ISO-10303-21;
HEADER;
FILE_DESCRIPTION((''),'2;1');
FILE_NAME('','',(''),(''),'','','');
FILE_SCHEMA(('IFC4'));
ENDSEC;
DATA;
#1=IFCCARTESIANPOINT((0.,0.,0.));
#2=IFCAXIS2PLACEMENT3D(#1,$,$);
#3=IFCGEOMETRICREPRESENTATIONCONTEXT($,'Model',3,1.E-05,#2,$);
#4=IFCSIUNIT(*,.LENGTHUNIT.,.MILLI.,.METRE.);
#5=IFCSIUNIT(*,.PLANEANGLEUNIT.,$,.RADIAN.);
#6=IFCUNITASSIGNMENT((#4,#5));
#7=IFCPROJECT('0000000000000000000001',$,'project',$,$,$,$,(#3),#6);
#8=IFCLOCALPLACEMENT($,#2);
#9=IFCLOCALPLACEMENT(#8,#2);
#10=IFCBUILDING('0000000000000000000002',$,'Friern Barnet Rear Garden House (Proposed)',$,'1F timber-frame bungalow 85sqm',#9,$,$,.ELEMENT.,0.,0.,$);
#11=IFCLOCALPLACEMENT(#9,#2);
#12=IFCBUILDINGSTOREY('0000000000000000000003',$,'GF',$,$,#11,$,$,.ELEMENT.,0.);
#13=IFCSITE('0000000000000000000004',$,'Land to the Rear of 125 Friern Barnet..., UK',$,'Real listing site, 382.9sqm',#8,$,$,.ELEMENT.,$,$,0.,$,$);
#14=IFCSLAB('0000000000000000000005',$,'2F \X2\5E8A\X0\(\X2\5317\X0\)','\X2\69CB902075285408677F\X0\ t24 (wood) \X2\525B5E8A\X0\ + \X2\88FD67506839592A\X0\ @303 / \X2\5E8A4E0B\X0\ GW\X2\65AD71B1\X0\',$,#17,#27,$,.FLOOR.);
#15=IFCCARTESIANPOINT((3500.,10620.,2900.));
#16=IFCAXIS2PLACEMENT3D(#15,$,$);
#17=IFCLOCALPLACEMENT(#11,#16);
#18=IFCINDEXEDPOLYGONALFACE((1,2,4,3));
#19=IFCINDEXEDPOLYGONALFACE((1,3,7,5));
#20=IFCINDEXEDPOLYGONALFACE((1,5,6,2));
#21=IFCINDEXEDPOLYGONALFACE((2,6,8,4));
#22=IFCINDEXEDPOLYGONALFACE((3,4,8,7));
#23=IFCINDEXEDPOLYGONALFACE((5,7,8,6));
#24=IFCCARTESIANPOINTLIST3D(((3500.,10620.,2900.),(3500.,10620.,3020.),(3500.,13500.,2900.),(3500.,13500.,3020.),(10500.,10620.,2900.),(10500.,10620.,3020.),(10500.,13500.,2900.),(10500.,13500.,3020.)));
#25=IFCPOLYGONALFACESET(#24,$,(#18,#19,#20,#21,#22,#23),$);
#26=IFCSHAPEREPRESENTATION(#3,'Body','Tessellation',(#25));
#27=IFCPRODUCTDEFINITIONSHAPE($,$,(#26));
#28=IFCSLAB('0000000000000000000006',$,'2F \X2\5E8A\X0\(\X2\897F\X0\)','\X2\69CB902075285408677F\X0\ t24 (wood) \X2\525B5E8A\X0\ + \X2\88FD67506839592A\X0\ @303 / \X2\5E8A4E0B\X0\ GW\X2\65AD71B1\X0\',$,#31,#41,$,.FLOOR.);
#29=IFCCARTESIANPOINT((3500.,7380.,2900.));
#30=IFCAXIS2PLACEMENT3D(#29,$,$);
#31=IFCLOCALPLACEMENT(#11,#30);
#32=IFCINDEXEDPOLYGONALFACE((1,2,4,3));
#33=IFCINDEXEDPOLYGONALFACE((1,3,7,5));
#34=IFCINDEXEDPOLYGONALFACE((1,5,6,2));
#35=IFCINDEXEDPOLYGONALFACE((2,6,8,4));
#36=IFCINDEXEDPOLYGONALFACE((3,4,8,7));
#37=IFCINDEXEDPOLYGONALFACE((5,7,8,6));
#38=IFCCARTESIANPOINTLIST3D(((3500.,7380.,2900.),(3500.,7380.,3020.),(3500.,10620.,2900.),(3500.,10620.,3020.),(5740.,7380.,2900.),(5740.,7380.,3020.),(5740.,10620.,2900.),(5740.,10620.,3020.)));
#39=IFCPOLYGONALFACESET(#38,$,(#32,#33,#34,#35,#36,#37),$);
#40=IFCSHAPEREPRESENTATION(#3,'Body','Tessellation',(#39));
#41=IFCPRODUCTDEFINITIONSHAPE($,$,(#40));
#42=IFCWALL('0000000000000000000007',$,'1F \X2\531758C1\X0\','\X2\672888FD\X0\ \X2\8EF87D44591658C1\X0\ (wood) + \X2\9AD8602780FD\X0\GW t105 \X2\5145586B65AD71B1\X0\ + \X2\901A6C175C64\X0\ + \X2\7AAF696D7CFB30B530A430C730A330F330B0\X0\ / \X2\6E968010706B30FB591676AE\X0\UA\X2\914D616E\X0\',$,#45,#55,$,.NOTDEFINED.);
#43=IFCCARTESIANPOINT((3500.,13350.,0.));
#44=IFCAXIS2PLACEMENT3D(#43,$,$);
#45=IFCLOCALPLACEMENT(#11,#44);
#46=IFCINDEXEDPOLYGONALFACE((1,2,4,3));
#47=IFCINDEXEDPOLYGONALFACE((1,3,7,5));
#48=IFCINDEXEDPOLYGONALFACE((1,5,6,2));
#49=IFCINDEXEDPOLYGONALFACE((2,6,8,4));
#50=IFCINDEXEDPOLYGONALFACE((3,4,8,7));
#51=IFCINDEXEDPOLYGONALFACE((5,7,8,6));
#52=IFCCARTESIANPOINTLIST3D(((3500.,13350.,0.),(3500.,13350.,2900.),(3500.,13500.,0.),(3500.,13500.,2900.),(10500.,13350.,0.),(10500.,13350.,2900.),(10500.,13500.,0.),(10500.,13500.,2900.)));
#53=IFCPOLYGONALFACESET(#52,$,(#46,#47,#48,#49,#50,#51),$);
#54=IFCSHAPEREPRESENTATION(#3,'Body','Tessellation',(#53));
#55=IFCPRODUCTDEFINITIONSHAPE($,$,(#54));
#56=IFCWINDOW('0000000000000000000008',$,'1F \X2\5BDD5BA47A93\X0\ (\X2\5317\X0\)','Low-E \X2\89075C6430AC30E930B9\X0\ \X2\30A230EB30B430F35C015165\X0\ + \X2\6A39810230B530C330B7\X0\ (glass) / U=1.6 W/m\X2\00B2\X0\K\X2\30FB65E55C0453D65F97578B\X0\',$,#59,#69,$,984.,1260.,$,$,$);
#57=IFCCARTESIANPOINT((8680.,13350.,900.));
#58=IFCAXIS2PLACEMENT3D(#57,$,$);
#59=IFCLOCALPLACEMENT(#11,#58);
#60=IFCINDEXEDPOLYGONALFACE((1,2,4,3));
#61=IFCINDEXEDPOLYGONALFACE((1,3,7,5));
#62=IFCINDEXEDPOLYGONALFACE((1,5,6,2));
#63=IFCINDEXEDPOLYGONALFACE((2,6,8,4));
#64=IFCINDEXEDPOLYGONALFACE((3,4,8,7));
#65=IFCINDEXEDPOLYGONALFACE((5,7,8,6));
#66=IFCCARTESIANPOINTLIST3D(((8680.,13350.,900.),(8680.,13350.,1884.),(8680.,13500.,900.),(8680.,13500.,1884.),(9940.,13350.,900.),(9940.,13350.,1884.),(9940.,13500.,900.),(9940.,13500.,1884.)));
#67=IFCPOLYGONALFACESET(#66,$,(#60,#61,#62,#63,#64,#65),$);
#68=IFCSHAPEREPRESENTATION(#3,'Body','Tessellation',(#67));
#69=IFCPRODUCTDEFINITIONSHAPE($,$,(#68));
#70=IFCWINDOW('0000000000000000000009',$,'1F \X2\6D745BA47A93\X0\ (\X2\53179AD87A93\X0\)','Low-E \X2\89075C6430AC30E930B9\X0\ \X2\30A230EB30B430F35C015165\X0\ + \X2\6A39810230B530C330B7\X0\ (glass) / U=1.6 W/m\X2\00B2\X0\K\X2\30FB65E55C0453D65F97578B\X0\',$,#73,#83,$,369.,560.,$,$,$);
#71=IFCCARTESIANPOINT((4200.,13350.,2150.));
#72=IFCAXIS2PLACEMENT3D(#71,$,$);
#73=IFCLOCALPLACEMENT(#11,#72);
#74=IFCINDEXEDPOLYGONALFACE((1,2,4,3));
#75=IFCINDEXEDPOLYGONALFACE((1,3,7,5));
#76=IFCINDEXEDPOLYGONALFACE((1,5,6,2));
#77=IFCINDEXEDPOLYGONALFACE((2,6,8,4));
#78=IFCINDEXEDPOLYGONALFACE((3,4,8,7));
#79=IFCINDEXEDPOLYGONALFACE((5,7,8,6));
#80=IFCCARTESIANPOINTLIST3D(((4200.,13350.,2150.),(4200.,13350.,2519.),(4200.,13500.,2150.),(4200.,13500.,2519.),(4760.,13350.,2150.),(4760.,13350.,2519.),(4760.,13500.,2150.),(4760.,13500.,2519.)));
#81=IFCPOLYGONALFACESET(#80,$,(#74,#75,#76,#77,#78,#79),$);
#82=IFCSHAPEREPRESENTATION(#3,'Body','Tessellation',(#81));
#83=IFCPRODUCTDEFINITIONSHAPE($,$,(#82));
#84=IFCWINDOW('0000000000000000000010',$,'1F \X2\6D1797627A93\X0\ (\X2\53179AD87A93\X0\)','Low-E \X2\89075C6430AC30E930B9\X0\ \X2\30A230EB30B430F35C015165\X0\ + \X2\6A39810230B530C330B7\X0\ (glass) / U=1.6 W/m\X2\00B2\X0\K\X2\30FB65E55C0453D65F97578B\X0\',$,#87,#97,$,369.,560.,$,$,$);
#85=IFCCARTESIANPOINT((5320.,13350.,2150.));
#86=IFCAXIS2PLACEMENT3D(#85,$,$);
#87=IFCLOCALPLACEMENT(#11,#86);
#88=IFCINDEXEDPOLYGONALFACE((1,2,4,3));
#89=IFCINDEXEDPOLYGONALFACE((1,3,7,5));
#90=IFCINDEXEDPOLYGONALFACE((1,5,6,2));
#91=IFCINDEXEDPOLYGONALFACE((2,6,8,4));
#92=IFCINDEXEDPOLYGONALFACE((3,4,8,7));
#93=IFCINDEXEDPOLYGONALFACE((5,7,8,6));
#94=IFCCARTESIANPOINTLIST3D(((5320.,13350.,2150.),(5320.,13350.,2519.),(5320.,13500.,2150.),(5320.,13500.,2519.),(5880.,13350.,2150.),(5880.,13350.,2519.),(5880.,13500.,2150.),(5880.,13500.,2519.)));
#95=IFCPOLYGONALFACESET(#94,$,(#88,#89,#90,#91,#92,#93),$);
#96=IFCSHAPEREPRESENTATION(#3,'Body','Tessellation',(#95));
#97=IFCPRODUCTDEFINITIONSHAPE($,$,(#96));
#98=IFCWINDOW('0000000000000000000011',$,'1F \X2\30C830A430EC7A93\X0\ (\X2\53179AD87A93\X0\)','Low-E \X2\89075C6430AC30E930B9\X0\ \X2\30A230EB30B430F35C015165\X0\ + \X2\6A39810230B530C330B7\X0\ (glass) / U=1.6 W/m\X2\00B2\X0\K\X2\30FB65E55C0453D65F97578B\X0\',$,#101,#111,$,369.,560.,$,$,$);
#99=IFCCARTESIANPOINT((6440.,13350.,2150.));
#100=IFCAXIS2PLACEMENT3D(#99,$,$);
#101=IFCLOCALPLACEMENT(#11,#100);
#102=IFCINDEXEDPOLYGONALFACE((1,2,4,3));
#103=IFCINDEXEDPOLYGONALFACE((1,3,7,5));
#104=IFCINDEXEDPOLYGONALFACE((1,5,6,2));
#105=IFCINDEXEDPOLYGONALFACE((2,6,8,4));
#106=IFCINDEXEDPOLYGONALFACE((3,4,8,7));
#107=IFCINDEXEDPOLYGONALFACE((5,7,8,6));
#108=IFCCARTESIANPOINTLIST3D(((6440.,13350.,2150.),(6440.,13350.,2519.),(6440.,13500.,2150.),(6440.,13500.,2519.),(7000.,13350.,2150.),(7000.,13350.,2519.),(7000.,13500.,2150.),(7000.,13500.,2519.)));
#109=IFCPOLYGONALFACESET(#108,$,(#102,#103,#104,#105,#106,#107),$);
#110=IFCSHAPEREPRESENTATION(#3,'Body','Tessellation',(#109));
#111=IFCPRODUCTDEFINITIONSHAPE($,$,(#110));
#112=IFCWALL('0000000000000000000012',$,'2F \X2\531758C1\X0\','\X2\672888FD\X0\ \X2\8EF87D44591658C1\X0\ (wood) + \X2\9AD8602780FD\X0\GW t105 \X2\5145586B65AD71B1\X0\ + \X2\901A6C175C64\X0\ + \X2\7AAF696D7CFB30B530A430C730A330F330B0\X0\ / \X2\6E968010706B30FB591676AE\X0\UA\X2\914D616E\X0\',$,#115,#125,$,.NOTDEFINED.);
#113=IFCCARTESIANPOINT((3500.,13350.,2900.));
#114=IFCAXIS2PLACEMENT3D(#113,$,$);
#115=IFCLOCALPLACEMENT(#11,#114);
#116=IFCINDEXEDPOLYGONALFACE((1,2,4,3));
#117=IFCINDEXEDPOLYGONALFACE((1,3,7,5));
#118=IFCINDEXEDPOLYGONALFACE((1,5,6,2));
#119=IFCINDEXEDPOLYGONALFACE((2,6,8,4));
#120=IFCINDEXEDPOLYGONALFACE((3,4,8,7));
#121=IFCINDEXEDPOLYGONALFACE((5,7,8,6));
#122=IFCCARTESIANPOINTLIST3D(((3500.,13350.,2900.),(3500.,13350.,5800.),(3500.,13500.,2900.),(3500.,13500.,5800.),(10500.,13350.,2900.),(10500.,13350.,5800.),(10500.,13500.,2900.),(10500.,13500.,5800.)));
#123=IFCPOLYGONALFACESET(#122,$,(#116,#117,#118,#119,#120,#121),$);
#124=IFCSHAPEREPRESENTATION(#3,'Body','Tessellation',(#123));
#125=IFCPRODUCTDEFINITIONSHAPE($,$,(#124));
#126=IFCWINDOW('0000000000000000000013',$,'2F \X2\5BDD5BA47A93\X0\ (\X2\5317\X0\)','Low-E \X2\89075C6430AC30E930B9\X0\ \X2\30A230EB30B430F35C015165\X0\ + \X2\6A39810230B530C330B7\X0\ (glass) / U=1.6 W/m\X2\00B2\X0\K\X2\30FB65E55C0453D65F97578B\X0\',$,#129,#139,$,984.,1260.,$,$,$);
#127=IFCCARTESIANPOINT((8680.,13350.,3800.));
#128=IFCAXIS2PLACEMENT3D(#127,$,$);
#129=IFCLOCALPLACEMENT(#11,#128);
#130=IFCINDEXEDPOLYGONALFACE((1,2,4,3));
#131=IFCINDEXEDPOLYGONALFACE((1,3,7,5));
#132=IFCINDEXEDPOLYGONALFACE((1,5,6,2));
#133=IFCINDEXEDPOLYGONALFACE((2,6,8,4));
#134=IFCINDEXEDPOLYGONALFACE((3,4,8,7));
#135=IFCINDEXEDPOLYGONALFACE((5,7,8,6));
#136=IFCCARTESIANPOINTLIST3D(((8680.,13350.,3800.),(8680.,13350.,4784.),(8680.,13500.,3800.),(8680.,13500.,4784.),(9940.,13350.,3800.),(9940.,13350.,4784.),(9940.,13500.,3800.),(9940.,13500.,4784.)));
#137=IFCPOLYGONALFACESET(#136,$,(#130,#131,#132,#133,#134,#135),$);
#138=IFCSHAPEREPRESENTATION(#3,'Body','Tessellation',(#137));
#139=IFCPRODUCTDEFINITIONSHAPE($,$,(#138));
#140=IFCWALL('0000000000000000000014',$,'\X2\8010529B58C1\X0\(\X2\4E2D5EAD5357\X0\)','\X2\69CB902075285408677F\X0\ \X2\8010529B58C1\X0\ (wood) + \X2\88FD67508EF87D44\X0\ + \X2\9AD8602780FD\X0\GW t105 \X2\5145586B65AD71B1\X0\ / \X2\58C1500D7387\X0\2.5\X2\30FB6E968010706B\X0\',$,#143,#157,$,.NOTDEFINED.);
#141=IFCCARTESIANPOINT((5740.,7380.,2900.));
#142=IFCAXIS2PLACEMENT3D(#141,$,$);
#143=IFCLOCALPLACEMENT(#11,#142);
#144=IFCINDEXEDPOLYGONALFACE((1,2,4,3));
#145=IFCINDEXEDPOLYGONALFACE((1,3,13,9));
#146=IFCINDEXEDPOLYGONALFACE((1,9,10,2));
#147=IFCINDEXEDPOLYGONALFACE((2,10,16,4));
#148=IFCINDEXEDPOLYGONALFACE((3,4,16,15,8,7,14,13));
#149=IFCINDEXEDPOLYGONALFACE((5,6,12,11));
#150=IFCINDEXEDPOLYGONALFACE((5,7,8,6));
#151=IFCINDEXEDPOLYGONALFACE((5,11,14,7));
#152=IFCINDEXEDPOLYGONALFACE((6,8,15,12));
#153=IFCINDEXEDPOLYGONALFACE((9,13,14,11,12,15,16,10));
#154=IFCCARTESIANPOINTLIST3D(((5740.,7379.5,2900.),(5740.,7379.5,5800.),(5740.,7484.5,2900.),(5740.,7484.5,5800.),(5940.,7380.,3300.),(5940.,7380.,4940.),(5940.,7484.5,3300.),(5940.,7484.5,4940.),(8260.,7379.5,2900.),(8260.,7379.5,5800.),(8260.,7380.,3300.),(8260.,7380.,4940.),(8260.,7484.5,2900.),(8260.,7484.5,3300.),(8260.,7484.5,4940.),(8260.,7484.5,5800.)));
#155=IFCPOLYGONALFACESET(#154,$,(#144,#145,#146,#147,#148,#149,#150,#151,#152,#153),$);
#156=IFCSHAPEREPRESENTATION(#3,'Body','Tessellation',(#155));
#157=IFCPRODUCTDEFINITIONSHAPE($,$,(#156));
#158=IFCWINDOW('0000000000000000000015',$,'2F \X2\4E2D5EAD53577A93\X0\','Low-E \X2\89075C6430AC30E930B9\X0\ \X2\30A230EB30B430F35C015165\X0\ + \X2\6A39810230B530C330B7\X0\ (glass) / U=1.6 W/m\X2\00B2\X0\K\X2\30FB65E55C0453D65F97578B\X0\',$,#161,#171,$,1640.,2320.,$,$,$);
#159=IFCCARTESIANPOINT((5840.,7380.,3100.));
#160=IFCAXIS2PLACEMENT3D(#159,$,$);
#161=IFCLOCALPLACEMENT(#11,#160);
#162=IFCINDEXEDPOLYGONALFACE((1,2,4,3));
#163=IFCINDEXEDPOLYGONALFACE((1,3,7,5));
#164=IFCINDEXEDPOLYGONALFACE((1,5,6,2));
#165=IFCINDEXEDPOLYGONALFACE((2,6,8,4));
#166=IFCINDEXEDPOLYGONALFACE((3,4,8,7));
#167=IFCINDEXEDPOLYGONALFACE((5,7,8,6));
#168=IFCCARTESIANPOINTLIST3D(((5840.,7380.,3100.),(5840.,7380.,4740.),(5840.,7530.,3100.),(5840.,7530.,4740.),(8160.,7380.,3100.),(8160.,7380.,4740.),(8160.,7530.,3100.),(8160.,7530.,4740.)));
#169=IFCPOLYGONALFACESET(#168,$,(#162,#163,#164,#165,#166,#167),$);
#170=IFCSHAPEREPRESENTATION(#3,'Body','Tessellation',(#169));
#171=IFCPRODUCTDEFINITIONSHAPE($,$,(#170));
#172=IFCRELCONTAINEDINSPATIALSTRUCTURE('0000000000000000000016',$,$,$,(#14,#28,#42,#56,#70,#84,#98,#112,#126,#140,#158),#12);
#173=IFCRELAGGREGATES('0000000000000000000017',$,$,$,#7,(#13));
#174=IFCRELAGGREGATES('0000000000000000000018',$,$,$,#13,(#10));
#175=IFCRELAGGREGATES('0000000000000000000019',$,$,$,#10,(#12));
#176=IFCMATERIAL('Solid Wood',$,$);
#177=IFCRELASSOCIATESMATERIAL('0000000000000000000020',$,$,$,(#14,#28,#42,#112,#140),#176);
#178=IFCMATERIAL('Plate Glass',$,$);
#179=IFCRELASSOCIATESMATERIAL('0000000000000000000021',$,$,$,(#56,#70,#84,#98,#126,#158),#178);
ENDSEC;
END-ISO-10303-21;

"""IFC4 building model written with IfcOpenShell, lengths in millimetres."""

from ifc_helpers import new_model, si_unit, frame, frame_2d, origin, place, context, project, spatial, rectangle, extrude, material, element, fill, save


model = new_model("IFC4")

# Units and contexts
model_context = context("Model", 3, precision=1e-05, world=origin())
ifc_project = project(units=[si_unit("LENGTHUNIT", "METRE", prefix="MILLI"), si_unit("PLANEANGLEUNIT", "RADIAN")], contexts=[model_context])

# Site, building, storey
site_placement = place(None, origin())
site = spatial("IfcSite", under=ifc_project, at=site_placement, Name="Land to the Rear of 125 Friern Barnet..., UK", ObjectType="Real listing site, 382.9sqm", CompositionType="ELEMENT", RefElevation=0.0)
building_placement = place(site_placement, origin())
building = spatial("IfcBuilding", under=site, at=building_placement, Name="Friern Barnet Rear Garden House (Proposed)", ObjectType="1F timber-frame bungalow 85sqm", CompositionType="ELEMENT", ElevationOfRefHeight=0.0, ElevationOfTerrain=0.0)
storey_placement = place(building_placement, origin())
storey = spatial("IfcBuildingStorey", under=building, at=storey_placement, Name="GF", CompositionType="ELEMENT", Elevation=0.0)

# Slabs
ifc_material_1 = material(Name="Solid Wood")
slab_1_placement = place(storey_placement, frame((3500.0, 10620.0, 2900.0)))
element("IfcSlab", 1, at=slab_1_placement, inside=storey, material=ifc_material_1, Name="2F 床(北)", Description="構造用合板 t24 (wood) 剛床 + 製材根太 @303 / 床下 GW断熱", PredefinedType="FLOOR", context=model_context, shape_type="SweptSolid", body=[
    extrude(rectangle(XDim=7000.0, YDim=2880.0, at=frame_2d((3500.0, 1440.0))), frame((3500.0, 10620.0, 2900.0)), (0.0, 0.0, 1.0), 120.0),
])
slab_2_placement = place(storey_placement, frame((3500.0, 7380.0, 2900.0)))
element("IfcSlab", 2, at=slab_2_placement, inside=storey, material=ifc_material_1, Name="2F 床(西)", Description="構造用合板 t24 (wood) 剛床 + 製材根太 @303 / 床下 GW断熱", PredefinedType="FLOOR", context=model_context, shape_type="SweptSolid", body=[
    extrude(rectangle(XDim=2240.0, YDim=3240.0, at=frame_2d((1120.0, 1620.0))), frame((3500.0, 7380.0, 2900.0)), (0.0, 0.0, 1.0), 120.0),
])

# Wall, openings, windows
wall_1_placement = place(storey_placement, frame((3500.0, 13350.0, 0.0)))
wall_1 = element("IfcWall", 3, at=wall_1_placement, inside=storey, material=ifc_material_1, Name="1F 北壁", Description="木製 軸組外壁 (wood) + 高性能GW t105 充填断熱 + 通気層 + 窯業系サイディング / 準耐火・外皮UA配慮", PredefinedType="NOTDEFINED", context=model_context, shape_type="SweptSolid", body=[
    extrude(rectangle(XDim=7000.0, YDim=150.0, at=frame_2d((3500.0, 75.0))), frame((3500.0, 13350.0, 0.0)), (0.0, 0.0, 1.0), 2900.0),
])
opening_1_placement = place(storey_placement, frame((8680.0, 13350.0, 900.0)))
opening_1 = element("IfcOpeningElement", 4, at=opening_1_placement, cuts=wall_1, PredefinedType="NOTDEFINED", context=model_context, shape_type="SweptSolid", body=[
    extrude(rectangle(XDim=1260.0, YDim=150.0, at=frame_2d((630.0, 75.0))), frame((8680.0, 13350.0, 900.0)), (0.0, 0.0, 1.0), 984.0),
])
opening_2_placement = place(storey_placement, frame((4200.0, 13350.0, 2150.0)))
opening_2 = element("IfcOpeningElement", 5, at=opening_2_placement, cuts=wall_1, PredefinedType="NOTDEFINED", context=model_context, shape_type="SweptSolid", body=[
    extrude(rectangle(XDim=560.0, YDim=150.0, at=frame_2d((280.0, 75.0))), frame((4200.0, 13350.0, 2150.0)), (0.0, 0.0, 1.0), 369.0),
])
opening_3_placement = place(storey_placement, frame((5320.0, 13350.0, 2150.0)))
opening_3 = element("IfcOpeningElement", 6, at=opening_3_placement, cuts=wall_1, PredefinedType="NOTDEFINED", context=model_context, shape_type="SweptSolid", body=[
    extrude(rectangle(XDim=560.0, YDim=150.0, at=frame_2d((280.0, 75.0))), frame((5320.0, 13350.0, 2150.0)), (0.0, 0.0, 1.0), 369.0),
])
opening_4_placement = place(storey_placement, frame((6440.0, 13350.0, 2150.0)))
opening_4 = element("IfcOpeningElement", 7, at=opening_4_placement, cuts=wall_1, PredefinedType="NOTDEFINED", context=model_context, shape_type="SweptSolid", body=[
    extrude(rectangle(XDim=560.0, YDim=150.0, at=frame_2d((280.0, 75.0))), frame((6440.0, 13350.0, 2150.0)), (0.0, 0.0, 1.0), 369.0),
])
ifc_material_2 = material(Name="Plate Glass")
window_1_placement = place(storey_placement, frame((8680.0, 13350.0, 900.0)))
window_1 = element("IfcWindow", 8, at=window_1_placement, inside=storey, material=ifc_material_2, Name="1F 寝室窓 (北)", Description="Low-E 複層ガラス アルゴン封入 + 樹脂サッシ (glass) / U=1.6 W/m²K・日射取得型", OverallHeight=984.0, OverallWidth=1260.0, context=model_context, shape_type="SweptSolid", body=[
    extrude(rectangle(XDim=1260.0, YDim=150.0, at=frame_2d((630.0, 75.0))), frame((8680.0, 13350.0, 900.0)), (0.0, 0.0, 1.0), 984.0),
])
fill(opening_1, window_1)
window_2_placement = place(storey_placement, frame((4200.0, 13350.0, 2150.0)))
window_2 = element("IfcWindow", 9, at=window_2_placement, inside=storey, material=ifc_material_2, Name="1F 浴室窓 (北高窓)", Description="Low-E 複層ガラス アルゴン封入 + 樹脂サッシ (glass) / U=1.6 W/m²K・日射取得型", OverallHeight=369.0, OverallWidth=560.0, context=model_context, shape_type="SweptSolid", body=[
    extrude(rectangle(XDim=560.0, YDim=150.0, at=frame_2d((280.0, 75.0))), frame((4200.0, 13350.0, 2150.0)), (0.0, 0.0, 1.0), 369.0),
])
fill(opening_2, window_2)
window_3_placement = place(storey_placement, frame((5320.0, 13350.0, 2150.0)))
window_3 = element("IfcWindow", 10, at=window_3_placement, inside=storey, material=ifc_material_2, Name="1F 洗面窓 (北高窓)", Description="Low-E 複層ガラス アルゴン封入 + 樹脂サッシ (glass) / U=1.6 W/m²K・日射取得型", OverallHeight=369.0, OverallWidth=560.0, context=model_context, shape_type="SweptSolid", body=[
    extrude(rectangle(XDim=560.0, YDim=150.0, at=frame_2d((280.0, 75.0))), frame((5320.0, 13350.0, 2150.0)), (0.0, 0.0, 1.0), 369.0),
])
fill(opening_3, window_3)
window_4_placement = place(storey_placement, frame((6440.0, 13350.0, 2150.0)))
window_4 = element("IfcWindow", 11, at=window_4_placement, inside=storey, material=ifc_material_2, Name="1F トイレ窓 (北高窓)", Description="Low-E 複層ガラス アルゴン封入 + 樹脂サッシ (glass) / U=1.6 W/m²K・日射取得型", OverallHeight=369.0, OverallWidth=560.0, context=model_context, shape_type="SweptSolid", body=[
    extrude(rectangle(XDim=560.0, YDim=150.0, at=frame_2d((280.0, 75.0))), frame((6440.0, 13350.0, 2150.0)), (0.0, 0.0, 1.0), 369.0),
])
fill(opening_4, window_4)

# Walls, openings, windows
wall_2_placement = place(storey_placement, frame((3500.0, 13350.0, 2900.0)))
wall_2 = element("IfcWall", 12, at=wall_2_placement, inside=storey, material=ifc_material_1, Name="2F 北壁", Description="木製 軸組外壁 (wood) + 高性能GW t105 充填断熱 + 通気層 + 窯業系サイディング / 準耐火・外皮UA配慮", PredefinedType="NOTDEFINED", context=model_context, shape_type="SweptSolid", body=[
    extrude(rectangle(XDim=7000.0, YDim=150.0, at=frame_2d((3500.0, 75.0))), frame((3500.0, 13350.0, 2900.0)), (0.0, 0.0, 1.0), 2900.0),
])
opening_5_placement = place(storey_placement, frame((8680.0, 13350.0, 3800.0)))
opening_5 = element("IfcOpeningElement", 13, at=opening_5_placement, cuts=wall_2, PredefinedType="NOTDEFINED", context=model_context, shape_type="SweptSolid", body=[
    extrude(rectangle(XDim=1260.0, YDim=150.0, at=frame_2d((630.0, 75.0))), frame((8680.0, 13350.0, 3800.0)), (0.0, 0.0, 1.0), 984.0),
])
window_5_placement = place(storey_placement, frame((8680.0, 13350.0, 3800.0)))
window_5 = element("IfcWindow", 14, at=window_5_placement, inside=storey, material=ifc_material_2, Name="2F 寝室窓 (北)", Description="Low-E 複層ガラス アルゴン封入 + 樹脂サッシ (glass) / U=1.6 W/m²K・日射取得型", OverallHeight=984.0, OverallWidth=1260.0, context=model_context, shape_type="SweptSolid", body=[
    extrude(rectangle(XDim=1260.0, YDim=150.0, at=frame_2d((630.0, 75.0))), frame((8680.0, 13350.0, 3800.0)), (0.0, 0.0, 1.0), 984.0),
])
fill(opening_5, window_5)
wall_3_placement = place(storey_placement, frame((5740.0, 7380.0, 2900.0)))
wall_3 = element("IfcWall", 15, at=wall_3_placement, inside=storey, material=ifc_material_1, Name="耐力壁(中庭南)", Description="構造用合板 耐力壁 (wood) + 製材軸組 + 高性能GW t105 充填断熱 / 壁倍率2.5・準耐火", PredefinedType="NOTDEFINED", context=model_context, shape_type="SweptSolid", body=[
    extrude(rectangle(XDim=2520.0, YDim=105.0, at=frame_2d((1260.0, 52.0))), frame((5740.0, 7380.0, 2900.0)), (0.0, 0.0, 1.0), 2900.0),
])
opening_6_placement = place(storey_placement, frame((5840.0, 7380.0, 3100.0)))
opening_6 = element("IfcOpeningElement", 16, at=opening_6_placement, cuts=wall_3, PredefinedType="NOTDEFINED", context=model_context, shape_type="SweptSolid", body=[
    extrude(rectangle(XDim=2320.0, YDim=150.0, at=frame_2d((1160.0, 75.0))), frame((5840.0, 7380.0, 3100.0)), (0.0, 0.0, 1.0), 1640.0),
])
window_6_placement = place(storey_placement, frame((5840.0, 7380.0, 3100.0)))
window_6 = element("IfcWindow", 17, at=window_6_placement, inside=storey, material=ifc_material_2, Name="2F 中庭南窓", Description="Low-E 複層ガラス アルゴン封入 + 樹脂サッシ (glass) / U=1.6 W/m²K・日射取得型", OverallHeight=1640.0, OverallWidth=2320.0, context=model_context, shape_type="SweptSolid", body=[
    extrude(rectangle(XDim=2320.0, YDim=150.0, at=frame_2d((1160.0, 75.0))), frame((5840.0, 7380.0, 3100.0)), (0.0, 0.0, 1.0), 1640.0),
])
fill(opening_6, window_6)

save(model, "model.ifc")
